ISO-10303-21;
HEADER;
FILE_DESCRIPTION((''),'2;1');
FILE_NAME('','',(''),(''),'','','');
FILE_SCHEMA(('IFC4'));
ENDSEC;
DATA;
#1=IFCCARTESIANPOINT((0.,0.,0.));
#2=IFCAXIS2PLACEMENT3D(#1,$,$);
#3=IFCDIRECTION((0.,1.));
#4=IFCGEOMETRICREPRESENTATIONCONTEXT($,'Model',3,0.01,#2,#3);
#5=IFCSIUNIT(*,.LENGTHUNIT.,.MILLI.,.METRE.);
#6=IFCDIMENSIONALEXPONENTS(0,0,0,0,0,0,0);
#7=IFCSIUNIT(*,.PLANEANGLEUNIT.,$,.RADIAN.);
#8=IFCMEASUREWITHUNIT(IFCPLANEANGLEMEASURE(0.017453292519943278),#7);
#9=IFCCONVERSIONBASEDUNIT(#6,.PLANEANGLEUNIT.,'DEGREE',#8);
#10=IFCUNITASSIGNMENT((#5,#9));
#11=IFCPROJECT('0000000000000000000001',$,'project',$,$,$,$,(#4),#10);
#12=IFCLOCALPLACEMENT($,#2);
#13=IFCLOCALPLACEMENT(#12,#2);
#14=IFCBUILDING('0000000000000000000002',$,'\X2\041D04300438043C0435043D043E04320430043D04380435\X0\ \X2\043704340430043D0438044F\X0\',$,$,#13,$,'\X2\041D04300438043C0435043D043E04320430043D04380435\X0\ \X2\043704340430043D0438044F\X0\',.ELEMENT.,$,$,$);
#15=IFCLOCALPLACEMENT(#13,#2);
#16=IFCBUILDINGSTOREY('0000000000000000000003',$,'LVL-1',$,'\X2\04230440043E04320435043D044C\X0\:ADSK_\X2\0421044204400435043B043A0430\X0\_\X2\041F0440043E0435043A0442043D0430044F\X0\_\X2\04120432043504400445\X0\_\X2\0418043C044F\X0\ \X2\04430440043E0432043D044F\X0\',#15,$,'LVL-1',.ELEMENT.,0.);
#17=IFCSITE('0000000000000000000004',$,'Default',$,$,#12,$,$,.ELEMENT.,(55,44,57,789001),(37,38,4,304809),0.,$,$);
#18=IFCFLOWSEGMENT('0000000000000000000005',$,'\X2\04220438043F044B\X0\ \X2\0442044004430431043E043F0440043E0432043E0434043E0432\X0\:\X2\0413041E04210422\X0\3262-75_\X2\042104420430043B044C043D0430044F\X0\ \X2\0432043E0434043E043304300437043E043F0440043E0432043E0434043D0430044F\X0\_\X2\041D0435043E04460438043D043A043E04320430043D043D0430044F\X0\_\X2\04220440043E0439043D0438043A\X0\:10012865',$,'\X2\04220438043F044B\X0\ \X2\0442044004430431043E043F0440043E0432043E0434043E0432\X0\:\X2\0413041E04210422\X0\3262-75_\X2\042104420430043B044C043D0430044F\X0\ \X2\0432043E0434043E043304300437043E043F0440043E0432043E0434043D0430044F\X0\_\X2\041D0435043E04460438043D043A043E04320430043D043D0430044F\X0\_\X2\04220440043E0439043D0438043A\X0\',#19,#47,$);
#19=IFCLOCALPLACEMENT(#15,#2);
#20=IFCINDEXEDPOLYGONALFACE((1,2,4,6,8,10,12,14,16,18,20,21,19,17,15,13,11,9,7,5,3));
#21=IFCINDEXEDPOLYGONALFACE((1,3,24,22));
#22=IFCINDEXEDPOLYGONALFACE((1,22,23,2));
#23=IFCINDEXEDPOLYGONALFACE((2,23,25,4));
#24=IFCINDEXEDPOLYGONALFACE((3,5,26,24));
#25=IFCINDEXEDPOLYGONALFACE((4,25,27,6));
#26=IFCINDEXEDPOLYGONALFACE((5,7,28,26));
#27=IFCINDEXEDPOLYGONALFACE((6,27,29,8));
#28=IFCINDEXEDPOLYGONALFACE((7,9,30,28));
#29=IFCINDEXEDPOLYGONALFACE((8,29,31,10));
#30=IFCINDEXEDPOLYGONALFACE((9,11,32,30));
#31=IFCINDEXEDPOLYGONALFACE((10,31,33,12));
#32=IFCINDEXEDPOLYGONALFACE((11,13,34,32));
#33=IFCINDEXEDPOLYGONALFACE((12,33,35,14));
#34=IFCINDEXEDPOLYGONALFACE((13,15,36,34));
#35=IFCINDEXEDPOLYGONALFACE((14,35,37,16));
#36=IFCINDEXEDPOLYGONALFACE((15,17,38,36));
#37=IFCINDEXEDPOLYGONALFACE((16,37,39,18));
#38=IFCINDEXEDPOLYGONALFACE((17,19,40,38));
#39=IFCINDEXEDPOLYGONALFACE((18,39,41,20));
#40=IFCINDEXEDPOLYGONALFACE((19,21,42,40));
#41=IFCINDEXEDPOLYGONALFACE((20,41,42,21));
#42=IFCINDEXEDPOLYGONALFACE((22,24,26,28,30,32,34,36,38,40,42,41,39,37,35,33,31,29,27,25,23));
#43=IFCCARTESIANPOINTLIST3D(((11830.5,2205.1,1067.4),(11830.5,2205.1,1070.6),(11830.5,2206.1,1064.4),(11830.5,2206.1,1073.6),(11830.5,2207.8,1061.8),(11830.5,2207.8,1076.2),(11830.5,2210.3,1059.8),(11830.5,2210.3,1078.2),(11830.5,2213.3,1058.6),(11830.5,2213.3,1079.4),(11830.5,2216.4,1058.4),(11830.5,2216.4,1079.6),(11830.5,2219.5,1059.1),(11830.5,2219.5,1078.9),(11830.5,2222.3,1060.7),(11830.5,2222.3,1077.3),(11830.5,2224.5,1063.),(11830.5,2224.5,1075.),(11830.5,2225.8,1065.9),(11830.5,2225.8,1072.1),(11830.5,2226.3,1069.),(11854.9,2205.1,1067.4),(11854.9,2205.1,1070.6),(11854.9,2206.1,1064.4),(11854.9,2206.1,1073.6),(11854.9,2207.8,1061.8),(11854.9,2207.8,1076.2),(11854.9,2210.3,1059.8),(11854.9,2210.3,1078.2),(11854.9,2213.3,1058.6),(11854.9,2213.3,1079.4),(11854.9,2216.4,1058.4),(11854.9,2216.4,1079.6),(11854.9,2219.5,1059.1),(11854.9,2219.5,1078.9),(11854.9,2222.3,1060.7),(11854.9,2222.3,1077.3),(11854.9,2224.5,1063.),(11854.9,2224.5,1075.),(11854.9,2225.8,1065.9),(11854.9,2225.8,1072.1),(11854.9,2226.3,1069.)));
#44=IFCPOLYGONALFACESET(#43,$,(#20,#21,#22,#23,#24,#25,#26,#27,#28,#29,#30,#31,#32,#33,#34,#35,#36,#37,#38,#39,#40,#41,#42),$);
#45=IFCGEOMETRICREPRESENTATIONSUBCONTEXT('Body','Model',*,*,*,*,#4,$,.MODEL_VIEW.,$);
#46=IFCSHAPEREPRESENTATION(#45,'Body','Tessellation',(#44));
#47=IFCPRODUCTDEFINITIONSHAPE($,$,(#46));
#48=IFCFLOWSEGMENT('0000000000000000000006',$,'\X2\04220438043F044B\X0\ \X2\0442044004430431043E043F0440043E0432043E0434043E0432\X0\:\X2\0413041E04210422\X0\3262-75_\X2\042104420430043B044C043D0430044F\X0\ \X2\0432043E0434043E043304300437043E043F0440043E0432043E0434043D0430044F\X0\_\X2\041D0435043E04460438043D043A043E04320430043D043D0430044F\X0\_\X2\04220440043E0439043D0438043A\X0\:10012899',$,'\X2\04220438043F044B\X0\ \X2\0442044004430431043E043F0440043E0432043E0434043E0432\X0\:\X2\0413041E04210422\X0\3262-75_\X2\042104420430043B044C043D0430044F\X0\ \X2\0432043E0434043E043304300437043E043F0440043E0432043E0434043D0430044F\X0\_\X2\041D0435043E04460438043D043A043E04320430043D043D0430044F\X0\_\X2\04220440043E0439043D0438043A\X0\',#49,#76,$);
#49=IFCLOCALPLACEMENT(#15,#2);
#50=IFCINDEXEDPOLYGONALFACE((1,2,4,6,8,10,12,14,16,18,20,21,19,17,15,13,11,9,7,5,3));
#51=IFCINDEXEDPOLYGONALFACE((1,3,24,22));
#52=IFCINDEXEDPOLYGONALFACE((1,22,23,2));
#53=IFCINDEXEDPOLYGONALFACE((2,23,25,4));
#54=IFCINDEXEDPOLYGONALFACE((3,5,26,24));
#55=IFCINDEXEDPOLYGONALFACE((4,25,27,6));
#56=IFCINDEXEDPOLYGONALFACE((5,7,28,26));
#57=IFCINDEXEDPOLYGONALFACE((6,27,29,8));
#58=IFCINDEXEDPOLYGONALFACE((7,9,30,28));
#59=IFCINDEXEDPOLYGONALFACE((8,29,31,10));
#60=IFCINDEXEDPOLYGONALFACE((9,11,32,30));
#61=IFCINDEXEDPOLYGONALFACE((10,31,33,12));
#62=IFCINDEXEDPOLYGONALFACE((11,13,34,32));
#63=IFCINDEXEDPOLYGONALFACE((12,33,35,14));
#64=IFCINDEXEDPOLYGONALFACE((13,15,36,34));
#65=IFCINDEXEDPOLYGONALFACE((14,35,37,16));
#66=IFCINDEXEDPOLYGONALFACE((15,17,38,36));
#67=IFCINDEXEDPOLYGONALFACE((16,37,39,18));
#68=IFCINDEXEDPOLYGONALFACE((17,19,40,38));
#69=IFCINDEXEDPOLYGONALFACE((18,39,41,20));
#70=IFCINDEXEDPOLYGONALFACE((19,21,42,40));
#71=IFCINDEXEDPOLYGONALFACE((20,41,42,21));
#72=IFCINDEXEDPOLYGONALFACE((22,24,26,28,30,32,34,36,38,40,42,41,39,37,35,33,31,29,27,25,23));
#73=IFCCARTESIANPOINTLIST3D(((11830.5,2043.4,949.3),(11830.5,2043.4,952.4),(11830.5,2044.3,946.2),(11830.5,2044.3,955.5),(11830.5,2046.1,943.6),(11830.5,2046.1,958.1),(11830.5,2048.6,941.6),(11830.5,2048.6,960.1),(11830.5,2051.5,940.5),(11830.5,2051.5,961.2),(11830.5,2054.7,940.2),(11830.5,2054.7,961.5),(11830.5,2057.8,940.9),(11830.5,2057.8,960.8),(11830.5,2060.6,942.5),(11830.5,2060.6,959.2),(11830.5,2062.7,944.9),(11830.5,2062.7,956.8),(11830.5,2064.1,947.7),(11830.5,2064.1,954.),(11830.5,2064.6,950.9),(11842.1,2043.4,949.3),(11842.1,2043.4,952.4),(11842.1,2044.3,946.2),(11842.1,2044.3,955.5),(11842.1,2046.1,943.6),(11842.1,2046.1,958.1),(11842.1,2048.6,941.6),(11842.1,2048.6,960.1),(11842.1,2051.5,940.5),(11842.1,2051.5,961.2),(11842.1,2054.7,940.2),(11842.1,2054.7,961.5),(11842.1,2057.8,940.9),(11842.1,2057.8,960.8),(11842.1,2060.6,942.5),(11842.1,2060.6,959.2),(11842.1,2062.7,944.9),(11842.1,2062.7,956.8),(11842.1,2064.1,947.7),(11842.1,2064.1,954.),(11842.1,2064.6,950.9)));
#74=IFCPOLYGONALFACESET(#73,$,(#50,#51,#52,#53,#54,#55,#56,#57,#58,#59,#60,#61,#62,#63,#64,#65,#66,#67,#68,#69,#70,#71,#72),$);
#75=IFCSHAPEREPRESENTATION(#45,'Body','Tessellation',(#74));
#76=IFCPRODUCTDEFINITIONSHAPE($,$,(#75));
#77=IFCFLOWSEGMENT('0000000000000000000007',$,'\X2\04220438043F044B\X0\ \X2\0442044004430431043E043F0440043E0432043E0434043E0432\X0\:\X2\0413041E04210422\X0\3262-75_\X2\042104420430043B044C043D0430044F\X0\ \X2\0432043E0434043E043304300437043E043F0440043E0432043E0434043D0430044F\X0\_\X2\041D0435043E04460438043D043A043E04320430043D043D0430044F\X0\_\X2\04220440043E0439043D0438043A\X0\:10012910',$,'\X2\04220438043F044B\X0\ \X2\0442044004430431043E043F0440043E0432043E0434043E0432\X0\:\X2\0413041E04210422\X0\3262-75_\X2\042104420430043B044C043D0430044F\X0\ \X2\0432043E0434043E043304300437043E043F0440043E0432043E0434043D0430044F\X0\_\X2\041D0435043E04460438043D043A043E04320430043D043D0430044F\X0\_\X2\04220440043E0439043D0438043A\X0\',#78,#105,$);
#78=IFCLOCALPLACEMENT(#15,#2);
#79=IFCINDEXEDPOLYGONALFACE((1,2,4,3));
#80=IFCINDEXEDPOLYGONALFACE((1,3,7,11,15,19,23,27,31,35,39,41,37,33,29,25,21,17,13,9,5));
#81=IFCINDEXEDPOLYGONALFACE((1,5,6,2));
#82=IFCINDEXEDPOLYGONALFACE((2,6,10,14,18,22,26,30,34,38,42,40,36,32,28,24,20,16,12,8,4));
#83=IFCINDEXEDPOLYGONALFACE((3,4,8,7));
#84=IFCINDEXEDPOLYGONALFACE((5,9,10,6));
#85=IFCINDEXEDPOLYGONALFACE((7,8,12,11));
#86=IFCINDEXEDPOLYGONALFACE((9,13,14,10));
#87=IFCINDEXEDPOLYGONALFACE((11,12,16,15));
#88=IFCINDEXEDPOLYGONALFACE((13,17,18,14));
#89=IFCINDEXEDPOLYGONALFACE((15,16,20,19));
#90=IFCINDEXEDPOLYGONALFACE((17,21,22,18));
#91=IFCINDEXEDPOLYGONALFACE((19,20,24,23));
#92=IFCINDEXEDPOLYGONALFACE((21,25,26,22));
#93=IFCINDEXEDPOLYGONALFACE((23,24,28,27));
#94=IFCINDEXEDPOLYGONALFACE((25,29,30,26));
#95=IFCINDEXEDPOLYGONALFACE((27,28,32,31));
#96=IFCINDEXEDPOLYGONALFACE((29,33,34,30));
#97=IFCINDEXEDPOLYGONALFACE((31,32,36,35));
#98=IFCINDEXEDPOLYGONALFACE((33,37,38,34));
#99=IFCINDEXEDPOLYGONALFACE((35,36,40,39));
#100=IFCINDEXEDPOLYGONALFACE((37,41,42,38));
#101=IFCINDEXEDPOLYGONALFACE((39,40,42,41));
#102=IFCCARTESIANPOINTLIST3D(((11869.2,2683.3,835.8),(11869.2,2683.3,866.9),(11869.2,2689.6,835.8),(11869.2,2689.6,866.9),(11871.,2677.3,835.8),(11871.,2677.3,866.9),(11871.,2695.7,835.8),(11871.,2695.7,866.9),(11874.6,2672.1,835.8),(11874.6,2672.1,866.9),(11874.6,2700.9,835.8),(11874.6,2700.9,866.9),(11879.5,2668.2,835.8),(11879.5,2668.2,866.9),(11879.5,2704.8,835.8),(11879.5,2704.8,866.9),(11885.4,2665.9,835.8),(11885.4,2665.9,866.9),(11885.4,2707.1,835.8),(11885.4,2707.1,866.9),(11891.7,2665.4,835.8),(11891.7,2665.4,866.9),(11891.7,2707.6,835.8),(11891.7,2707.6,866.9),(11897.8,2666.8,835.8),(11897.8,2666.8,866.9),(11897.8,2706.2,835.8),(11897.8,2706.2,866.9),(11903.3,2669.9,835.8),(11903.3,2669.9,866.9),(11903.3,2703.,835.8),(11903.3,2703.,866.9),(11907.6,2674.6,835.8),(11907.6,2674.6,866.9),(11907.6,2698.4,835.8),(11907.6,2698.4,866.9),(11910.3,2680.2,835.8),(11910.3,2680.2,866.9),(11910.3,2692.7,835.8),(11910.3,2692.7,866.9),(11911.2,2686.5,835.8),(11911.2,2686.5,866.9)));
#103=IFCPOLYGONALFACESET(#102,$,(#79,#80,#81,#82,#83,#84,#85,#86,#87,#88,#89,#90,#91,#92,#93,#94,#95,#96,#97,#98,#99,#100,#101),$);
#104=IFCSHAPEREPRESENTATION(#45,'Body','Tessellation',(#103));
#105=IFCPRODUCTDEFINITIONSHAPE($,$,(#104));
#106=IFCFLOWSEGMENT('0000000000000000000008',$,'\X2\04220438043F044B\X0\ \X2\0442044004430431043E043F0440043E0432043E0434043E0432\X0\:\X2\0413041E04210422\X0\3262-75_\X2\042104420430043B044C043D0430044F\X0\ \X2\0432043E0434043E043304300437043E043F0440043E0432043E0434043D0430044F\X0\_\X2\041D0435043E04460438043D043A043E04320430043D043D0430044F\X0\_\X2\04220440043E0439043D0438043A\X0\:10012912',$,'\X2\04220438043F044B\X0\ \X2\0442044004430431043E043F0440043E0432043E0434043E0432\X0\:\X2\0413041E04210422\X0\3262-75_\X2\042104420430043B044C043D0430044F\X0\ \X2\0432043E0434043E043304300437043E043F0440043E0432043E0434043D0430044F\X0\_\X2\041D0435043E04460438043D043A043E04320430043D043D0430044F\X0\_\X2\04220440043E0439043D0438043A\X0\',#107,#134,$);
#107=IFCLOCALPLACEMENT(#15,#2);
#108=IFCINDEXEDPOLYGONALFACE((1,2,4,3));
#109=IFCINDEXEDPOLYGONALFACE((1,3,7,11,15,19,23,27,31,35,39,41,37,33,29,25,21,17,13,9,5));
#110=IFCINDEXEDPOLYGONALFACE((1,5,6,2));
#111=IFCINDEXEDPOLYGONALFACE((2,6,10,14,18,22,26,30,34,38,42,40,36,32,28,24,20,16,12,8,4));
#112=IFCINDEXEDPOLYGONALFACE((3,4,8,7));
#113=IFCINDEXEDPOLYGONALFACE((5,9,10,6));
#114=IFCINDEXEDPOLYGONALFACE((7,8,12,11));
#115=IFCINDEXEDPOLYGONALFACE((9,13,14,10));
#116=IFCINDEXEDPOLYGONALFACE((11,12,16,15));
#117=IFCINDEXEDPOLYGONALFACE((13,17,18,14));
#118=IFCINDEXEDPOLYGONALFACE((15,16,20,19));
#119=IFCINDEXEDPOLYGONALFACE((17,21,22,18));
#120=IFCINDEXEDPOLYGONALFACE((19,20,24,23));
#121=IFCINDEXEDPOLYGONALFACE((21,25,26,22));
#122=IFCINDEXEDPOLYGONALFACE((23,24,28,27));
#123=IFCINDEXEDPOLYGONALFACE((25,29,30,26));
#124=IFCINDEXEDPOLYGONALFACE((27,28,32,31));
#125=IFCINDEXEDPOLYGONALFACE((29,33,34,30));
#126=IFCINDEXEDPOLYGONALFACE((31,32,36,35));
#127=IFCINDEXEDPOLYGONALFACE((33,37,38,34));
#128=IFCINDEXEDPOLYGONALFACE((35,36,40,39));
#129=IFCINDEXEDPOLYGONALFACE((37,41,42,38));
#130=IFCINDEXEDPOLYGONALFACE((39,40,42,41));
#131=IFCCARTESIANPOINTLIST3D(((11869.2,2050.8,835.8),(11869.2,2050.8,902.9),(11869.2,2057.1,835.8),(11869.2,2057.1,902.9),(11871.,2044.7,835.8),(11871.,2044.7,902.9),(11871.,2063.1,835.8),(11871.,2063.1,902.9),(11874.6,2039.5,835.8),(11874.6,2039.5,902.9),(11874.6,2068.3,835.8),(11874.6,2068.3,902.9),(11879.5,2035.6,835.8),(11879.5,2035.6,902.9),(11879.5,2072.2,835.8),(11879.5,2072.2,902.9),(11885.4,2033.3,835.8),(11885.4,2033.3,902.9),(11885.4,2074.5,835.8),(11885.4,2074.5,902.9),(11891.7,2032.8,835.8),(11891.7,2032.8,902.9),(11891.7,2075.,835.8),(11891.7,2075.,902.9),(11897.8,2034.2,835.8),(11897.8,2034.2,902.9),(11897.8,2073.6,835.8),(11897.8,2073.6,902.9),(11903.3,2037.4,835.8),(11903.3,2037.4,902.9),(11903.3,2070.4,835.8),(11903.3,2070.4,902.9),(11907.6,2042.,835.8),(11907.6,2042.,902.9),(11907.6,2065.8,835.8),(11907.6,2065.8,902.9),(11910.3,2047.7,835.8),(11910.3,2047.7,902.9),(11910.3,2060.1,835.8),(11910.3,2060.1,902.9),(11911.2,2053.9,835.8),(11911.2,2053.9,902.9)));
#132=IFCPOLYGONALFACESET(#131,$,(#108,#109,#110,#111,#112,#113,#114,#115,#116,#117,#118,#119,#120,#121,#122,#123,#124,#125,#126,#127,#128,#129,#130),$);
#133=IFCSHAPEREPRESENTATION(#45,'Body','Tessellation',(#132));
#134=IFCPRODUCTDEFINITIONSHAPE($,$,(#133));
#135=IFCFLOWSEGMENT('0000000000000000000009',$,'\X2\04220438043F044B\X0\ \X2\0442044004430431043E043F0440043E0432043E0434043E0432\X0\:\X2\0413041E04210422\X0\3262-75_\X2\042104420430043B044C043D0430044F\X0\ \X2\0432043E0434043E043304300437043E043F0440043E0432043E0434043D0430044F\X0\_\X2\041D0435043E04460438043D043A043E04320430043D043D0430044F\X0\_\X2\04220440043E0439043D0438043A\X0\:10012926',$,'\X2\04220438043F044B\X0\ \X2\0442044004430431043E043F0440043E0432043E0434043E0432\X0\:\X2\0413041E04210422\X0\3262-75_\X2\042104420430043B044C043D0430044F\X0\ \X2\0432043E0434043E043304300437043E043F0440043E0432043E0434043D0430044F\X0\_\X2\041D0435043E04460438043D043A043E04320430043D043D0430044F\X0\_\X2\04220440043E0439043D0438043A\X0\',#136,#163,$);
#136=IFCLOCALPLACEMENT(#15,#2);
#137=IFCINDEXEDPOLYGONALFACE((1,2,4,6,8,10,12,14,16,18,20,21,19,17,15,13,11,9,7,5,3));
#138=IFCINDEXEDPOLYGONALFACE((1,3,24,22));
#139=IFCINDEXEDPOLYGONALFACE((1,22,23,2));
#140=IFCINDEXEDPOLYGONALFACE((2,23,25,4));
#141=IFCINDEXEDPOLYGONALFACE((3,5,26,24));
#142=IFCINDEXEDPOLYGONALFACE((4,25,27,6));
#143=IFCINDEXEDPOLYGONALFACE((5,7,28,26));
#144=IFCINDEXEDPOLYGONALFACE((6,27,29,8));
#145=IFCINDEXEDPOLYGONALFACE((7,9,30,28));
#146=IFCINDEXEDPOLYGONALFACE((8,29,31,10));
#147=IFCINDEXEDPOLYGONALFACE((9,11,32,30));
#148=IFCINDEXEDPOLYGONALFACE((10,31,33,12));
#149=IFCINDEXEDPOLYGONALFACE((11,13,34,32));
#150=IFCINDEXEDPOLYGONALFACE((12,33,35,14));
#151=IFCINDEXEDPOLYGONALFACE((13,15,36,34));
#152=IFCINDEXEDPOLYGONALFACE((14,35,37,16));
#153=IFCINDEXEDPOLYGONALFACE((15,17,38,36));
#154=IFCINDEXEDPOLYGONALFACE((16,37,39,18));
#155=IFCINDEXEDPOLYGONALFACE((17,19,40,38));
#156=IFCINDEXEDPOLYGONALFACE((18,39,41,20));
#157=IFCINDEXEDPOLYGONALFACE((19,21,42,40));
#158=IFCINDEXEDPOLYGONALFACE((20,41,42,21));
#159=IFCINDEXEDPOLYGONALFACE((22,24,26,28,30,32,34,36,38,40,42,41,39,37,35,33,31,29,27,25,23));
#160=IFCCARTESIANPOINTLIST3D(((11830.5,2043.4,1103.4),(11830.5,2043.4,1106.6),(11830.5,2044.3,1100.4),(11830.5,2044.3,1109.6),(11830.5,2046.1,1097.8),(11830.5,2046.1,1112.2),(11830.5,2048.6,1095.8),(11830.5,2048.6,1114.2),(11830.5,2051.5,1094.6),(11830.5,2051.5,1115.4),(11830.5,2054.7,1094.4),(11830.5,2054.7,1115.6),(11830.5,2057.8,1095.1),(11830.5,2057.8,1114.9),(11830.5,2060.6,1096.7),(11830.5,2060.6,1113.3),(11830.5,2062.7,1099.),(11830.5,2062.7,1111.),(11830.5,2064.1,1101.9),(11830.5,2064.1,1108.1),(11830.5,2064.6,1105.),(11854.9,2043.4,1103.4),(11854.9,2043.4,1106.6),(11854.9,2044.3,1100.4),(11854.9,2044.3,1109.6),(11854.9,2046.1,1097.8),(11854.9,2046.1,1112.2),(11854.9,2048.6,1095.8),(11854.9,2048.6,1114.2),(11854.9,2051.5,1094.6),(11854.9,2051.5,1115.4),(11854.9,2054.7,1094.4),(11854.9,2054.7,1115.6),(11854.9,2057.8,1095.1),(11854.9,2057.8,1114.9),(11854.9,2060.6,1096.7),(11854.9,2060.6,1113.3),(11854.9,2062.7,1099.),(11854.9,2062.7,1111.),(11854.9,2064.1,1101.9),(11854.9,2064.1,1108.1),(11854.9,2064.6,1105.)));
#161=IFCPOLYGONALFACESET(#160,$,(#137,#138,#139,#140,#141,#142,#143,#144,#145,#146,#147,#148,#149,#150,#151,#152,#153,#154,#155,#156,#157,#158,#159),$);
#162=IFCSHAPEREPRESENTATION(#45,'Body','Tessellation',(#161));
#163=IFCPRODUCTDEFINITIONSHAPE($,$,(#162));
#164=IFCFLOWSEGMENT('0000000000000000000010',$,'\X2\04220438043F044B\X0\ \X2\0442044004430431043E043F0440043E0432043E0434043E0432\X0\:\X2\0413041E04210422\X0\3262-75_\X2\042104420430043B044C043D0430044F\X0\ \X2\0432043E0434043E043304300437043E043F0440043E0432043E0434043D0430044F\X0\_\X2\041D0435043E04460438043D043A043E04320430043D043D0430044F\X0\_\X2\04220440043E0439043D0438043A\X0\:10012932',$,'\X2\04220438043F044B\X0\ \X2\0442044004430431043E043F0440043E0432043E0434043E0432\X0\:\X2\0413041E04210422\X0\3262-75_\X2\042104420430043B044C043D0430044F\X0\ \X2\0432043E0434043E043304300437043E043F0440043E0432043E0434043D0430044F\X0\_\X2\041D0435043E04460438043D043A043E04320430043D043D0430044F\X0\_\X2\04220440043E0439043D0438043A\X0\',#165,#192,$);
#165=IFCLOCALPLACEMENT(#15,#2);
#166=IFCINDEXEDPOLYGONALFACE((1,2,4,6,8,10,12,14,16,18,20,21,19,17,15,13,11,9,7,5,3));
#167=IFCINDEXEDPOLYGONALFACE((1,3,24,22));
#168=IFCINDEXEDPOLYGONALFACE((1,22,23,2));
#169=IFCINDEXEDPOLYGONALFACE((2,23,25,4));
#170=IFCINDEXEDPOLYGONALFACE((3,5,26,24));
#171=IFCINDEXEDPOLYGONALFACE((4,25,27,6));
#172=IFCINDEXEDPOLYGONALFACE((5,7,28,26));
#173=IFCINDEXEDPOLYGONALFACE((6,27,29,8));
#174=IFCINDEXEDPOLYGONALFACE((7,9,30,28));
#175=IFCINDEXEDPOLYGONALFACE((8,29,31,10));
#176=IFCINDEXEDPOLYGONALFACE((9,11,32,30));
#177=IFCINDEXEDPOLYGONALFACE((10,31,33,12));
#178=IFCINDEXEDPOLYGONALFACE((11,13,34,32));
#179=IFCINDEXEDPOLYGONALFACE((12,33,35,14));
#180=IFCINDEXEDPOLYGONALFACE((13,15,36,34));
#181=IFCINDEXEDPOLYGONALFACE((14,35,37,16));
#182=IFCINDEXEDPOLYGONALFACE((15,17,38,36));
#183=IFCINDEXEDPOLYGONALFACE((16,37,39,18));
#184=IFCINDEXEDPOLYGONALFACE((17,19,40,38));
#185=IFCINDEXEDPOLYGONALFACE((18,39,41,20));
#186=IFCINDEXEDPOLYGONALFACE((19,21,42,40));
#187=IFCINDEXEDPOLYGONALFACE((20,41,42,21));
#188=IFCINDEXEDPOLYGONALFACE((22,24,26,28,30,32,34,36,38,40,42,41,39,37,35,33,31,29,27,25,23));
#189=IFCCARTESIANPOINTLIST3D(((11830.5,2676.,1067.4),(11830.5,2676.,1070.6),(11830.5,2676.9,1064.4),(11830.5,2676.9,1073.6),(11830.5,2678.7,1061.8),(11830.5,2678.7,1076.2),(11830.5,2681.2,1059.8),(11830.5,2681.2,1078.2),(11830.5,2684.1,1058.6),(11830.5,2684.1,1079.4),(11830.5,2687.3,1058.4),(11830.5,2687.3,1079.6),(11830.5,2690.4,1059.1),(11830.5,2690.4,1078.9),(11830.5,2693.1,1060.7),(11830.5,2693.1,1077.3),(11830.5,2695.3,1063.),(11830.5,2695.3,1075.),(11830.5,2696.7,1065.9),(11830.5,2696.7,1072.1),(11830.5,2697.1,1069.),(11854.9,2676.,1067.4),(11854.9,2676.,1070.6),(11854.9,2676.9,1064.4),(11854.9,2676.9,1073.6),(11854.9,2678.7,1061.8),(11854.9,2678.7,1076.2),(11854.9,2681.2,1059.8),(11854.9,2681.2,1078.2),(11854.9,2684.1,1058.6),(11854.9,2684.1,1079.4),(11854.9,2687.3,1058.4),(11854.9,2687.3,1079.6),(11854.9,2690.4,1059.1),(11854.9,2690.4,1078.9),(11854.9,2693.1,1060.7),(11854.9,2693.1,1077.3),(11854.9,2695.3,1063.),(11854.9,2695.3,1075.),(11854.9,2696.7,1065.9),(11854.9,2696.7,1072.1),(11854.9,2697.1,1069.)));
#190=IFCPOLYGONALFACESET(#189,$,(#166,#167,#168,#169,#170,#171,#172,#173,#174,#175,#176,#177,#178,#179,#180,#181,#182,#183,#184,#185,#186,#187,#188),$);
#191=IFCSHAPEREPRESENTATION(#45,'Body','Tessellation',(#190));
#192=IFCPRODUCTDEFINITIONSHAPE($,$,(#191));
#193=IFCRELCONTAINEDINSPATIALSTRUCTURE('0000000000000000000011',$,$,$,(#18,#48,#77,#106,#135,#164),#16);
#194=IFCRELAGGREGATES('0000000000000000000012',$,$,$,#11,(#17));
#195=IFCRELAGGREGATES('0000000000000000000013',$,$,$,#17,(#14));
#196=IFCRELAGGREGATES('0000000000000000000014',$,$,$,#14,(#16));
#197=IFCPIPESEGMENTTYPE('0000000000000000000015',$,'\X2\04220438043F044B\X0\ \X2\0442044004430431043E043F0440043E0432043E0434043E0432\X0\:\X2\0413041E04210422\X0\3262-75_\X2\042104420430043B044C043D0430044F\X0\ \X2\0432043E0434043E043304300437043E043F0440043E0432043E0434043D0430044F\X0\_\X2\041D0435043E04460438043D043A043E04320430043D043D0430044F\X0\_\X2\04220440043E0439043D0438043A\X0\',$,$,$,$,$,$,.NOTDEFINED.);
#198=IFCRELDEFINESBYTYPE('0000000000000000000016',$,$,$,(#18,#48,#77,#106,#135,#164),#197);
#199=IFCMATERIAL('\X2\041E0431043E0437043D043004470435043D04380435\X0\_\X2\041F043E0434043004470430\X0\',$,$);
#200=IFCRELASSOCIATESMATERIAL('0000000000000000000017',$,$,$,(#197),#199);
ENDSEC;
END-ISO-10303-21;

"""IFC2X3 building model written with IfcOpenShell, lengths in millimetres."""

from ifc_helpers import new_model, entity, si_unit, converted_unit, direction, frame, origin, origin_2d_with_axis, place, context, subcontext, project, spatial, circle, extrude, material, type_object, element, save


model = new_model("IFC2X3")

# Units and contexts
model_context = context("Model", 3, precision=0.01, world=origin(), true_north=direction((0.0, 1.0)))
body_context = subcontext(model_context, "Body", "Model", "MODEL_VIEW")
ifc_project = project(units=[si_unit("LENGTHUNIT", "METRE", prefix="MILLI"), converted_unit("PLANEANGLEUNIT", "DEGREE", entity("IfcPlaneAngleMeasure", 0.017453292519943278), si_unit("PLANEANGLEUNIT", "RADIAN"), dimensions=[0, 0, 0, 0, 0, 0, 0])], contexts=[model_context])

# Site, building, storey
site_placement = place(None, origin())
site = spatial("IfcSite", under=ifc_project, at=site_placement, Name="Default", CompositionType="ELEMENT", RefLatitude=(55, 44, 57, 789001), RefLongitude=(37, 38, 4, 304809), RefElevation=0.0)
building_placement = place(site_placement, origin())
building = spatial("IfcBuilding", under=site, at=building_placement, Name="Наименование здания", LongName="Наименование здания", CompositionType="ELEMENT")
storey_placement = place(building_placement, origin())
storey = spatial("IfcBuildingStorey", under=building, at=storey_placement, Name="LVL-1", ObjectType="Уровень:ADSK_Стрелка_Проектная_Вверх_Имя уровня", LongName="LVL-1", CompositionType="ELEMENT", Elevation=0.0)

# Flow segments
ifc_material_1 = material(Name="Обозначение_Подача")
pipe_segment_type_1 = type_object("IfcPipeSegmentType", Name="Типы трубопроводов:ГОСТ3262-75_Стальная водогазопроводная_Неоцинкованная_Тройник", PredefinedType="NOTDEFINED", material=ifc_material_1)
flow_segment_1_placement = place(storey_placement, origin())
element("IfcFlowSegment", 1, at=flow_segment_1_placement, inside=storey, type_object=pipe_segment_type_1, Name="Типы трубопроводов:ГОСТ3262-75_Стальная водогазопроводная_Неоцинкованная_Тройник:10012865", ObjectType="Типы трубопроводов:ГОСТ3262-75_Стальная водогазопроводная_Неоцинкованная_Тройник", context=body_context, shape_type="SweptSolid", body=[
    extrude(circle(Radius=10.7, at=origin_2d_with_axis()), frame((11830.5, 2215.7, 1069.0), z_axis=(1.0, 0.0, 0.0), x_axis=(0.0, 1.0, 0.0)), (0.0, 0.0, 1.0), 24.4),
])
flow_segment_2_placement = place(storey_placement, origin())
element("IfcFlowSegment", 2, at=flow_segment_2_placement, inside=storey, type_object=pipe_segment_type_1, Name="Типы трубопроводов:ГОСТ3262-75_Стальная водогазопроводная_Неоцинкованная_Тройник:10012899", ObjectType="Типы трубопроводов:ГОСТ3262-75_Стальная водогазопроводная_Неоцинкованная_Тройник", context=body_context, shape_type="SweptSolid", body=[
    extrude(circle(Radius=10.7, at=origin_2d_with_axis()), frame((11830.5, 2053.9, 950.9), z_axis=(1.0, 0.0, 0.0), x_axis=(0.0, 1.0, 0.0)), (0.0, 0.0, 1.0), 11.6),
])
flow_segment_3_placement = place(storey_placement, origin())
element("IfcFlowSegment", 3, at=flow_segment_3_placement, inside=storey, type_object=pipe_segment_type_1, Name="Типы трубопроводов:ГОСТ3262-75_Стальная водогазопроводная_Неоцинкованная_Тройник:10012910", ObjectType="Типы трубопроводов:ГОСТ3262-75_Стальная водогазопроводная_Неоцинкованная_Тройник", context=body_context, shape_type="SweptSolid", body=[
    extrude(circle(Radius=21.1, at=origin_2d_with_axis()), frame((11890.1, 2686.5, 835.8)), (0.0, 0.0, 1.0), 31.1),
])
flow_segment_4_placement = place(storey_placement, origin())
element("IfcFlowSegment", 4, at=flow_segment_4_placement, inside=storey, type_object=pipe_segment_type_1, Name="Типы трубопроводов:ГОСТ3262-75_Стальная водогазопроводная_Неоцинкованная_Тройник:10012912", ObjectType="Типы трубопроводов:ГОСТ3262-75_Стальная водогазопроводная_Неоцинкованная_Тройник", context=body_context, shape_type="SweptSolid", body=[
    extrude(circle(Radius=21.1, at=origin_2d_with_axis()), frame((11890.1, 2053.9, 835.8)), (0.0, 0.0, 1.0), 67.1),
])
flow_segment_5_placement = place(storey_placement, origin())
element("IfcFlowSegment", 5, at=flow_segment_5_placement, inside=storey, type_object=pipe_segment_type_1, Name="Типы трубопроводов:ГОСТ3262-75_Стальная водогазопроводная_Неоцинкованная_Тройник:10012926", ObjectType="Типы трубопроводов:ГОСТ3262-75_Стальная водогазопроводная_Неоцинкованная_Тройник", context=body_context, shape_type="SweptSolid", body=[
    extrude(circle(Radius=10.7, at=origin_2d_with_axis()), frame((11830.5, 2053.9, 1105.0), z_axis=(1.0, 0.0, 0.0), x_axis=(0.0, 1.0, 0.0)), (0.0, 0.0, 1.0), 24.4),
])
flow_segment_6_placement = place(storey_placement, origin())
element("IfcFlowSegment", 6, at=flow_segment_6_placement, inside=storey, type_object=pipe_segment_type_1, Name="Типы трубопроводов:ГОСТ3262-75_Стальная водогазопроводная_Неоцинкованная_Тройник:10012932", ObjectType="Типы трубопроводов:ГОСТ3262-75_Стальная водогазопроводная_Неоцинкованная_Тройник", context=body_context, shape_type="SweptSolid", body=[
    extrude(circle(Radius=10.7, at=origin_2d_with_axis()), frame((11830.5, 2686.5, 1069.0), z_axis=(1.0, 0.0, 0.0), x_axis=(0.0, 1.0, 0.0)), (0.0, 0.0, 1.0), 24.4),
])

save(model, "model.ifc")
